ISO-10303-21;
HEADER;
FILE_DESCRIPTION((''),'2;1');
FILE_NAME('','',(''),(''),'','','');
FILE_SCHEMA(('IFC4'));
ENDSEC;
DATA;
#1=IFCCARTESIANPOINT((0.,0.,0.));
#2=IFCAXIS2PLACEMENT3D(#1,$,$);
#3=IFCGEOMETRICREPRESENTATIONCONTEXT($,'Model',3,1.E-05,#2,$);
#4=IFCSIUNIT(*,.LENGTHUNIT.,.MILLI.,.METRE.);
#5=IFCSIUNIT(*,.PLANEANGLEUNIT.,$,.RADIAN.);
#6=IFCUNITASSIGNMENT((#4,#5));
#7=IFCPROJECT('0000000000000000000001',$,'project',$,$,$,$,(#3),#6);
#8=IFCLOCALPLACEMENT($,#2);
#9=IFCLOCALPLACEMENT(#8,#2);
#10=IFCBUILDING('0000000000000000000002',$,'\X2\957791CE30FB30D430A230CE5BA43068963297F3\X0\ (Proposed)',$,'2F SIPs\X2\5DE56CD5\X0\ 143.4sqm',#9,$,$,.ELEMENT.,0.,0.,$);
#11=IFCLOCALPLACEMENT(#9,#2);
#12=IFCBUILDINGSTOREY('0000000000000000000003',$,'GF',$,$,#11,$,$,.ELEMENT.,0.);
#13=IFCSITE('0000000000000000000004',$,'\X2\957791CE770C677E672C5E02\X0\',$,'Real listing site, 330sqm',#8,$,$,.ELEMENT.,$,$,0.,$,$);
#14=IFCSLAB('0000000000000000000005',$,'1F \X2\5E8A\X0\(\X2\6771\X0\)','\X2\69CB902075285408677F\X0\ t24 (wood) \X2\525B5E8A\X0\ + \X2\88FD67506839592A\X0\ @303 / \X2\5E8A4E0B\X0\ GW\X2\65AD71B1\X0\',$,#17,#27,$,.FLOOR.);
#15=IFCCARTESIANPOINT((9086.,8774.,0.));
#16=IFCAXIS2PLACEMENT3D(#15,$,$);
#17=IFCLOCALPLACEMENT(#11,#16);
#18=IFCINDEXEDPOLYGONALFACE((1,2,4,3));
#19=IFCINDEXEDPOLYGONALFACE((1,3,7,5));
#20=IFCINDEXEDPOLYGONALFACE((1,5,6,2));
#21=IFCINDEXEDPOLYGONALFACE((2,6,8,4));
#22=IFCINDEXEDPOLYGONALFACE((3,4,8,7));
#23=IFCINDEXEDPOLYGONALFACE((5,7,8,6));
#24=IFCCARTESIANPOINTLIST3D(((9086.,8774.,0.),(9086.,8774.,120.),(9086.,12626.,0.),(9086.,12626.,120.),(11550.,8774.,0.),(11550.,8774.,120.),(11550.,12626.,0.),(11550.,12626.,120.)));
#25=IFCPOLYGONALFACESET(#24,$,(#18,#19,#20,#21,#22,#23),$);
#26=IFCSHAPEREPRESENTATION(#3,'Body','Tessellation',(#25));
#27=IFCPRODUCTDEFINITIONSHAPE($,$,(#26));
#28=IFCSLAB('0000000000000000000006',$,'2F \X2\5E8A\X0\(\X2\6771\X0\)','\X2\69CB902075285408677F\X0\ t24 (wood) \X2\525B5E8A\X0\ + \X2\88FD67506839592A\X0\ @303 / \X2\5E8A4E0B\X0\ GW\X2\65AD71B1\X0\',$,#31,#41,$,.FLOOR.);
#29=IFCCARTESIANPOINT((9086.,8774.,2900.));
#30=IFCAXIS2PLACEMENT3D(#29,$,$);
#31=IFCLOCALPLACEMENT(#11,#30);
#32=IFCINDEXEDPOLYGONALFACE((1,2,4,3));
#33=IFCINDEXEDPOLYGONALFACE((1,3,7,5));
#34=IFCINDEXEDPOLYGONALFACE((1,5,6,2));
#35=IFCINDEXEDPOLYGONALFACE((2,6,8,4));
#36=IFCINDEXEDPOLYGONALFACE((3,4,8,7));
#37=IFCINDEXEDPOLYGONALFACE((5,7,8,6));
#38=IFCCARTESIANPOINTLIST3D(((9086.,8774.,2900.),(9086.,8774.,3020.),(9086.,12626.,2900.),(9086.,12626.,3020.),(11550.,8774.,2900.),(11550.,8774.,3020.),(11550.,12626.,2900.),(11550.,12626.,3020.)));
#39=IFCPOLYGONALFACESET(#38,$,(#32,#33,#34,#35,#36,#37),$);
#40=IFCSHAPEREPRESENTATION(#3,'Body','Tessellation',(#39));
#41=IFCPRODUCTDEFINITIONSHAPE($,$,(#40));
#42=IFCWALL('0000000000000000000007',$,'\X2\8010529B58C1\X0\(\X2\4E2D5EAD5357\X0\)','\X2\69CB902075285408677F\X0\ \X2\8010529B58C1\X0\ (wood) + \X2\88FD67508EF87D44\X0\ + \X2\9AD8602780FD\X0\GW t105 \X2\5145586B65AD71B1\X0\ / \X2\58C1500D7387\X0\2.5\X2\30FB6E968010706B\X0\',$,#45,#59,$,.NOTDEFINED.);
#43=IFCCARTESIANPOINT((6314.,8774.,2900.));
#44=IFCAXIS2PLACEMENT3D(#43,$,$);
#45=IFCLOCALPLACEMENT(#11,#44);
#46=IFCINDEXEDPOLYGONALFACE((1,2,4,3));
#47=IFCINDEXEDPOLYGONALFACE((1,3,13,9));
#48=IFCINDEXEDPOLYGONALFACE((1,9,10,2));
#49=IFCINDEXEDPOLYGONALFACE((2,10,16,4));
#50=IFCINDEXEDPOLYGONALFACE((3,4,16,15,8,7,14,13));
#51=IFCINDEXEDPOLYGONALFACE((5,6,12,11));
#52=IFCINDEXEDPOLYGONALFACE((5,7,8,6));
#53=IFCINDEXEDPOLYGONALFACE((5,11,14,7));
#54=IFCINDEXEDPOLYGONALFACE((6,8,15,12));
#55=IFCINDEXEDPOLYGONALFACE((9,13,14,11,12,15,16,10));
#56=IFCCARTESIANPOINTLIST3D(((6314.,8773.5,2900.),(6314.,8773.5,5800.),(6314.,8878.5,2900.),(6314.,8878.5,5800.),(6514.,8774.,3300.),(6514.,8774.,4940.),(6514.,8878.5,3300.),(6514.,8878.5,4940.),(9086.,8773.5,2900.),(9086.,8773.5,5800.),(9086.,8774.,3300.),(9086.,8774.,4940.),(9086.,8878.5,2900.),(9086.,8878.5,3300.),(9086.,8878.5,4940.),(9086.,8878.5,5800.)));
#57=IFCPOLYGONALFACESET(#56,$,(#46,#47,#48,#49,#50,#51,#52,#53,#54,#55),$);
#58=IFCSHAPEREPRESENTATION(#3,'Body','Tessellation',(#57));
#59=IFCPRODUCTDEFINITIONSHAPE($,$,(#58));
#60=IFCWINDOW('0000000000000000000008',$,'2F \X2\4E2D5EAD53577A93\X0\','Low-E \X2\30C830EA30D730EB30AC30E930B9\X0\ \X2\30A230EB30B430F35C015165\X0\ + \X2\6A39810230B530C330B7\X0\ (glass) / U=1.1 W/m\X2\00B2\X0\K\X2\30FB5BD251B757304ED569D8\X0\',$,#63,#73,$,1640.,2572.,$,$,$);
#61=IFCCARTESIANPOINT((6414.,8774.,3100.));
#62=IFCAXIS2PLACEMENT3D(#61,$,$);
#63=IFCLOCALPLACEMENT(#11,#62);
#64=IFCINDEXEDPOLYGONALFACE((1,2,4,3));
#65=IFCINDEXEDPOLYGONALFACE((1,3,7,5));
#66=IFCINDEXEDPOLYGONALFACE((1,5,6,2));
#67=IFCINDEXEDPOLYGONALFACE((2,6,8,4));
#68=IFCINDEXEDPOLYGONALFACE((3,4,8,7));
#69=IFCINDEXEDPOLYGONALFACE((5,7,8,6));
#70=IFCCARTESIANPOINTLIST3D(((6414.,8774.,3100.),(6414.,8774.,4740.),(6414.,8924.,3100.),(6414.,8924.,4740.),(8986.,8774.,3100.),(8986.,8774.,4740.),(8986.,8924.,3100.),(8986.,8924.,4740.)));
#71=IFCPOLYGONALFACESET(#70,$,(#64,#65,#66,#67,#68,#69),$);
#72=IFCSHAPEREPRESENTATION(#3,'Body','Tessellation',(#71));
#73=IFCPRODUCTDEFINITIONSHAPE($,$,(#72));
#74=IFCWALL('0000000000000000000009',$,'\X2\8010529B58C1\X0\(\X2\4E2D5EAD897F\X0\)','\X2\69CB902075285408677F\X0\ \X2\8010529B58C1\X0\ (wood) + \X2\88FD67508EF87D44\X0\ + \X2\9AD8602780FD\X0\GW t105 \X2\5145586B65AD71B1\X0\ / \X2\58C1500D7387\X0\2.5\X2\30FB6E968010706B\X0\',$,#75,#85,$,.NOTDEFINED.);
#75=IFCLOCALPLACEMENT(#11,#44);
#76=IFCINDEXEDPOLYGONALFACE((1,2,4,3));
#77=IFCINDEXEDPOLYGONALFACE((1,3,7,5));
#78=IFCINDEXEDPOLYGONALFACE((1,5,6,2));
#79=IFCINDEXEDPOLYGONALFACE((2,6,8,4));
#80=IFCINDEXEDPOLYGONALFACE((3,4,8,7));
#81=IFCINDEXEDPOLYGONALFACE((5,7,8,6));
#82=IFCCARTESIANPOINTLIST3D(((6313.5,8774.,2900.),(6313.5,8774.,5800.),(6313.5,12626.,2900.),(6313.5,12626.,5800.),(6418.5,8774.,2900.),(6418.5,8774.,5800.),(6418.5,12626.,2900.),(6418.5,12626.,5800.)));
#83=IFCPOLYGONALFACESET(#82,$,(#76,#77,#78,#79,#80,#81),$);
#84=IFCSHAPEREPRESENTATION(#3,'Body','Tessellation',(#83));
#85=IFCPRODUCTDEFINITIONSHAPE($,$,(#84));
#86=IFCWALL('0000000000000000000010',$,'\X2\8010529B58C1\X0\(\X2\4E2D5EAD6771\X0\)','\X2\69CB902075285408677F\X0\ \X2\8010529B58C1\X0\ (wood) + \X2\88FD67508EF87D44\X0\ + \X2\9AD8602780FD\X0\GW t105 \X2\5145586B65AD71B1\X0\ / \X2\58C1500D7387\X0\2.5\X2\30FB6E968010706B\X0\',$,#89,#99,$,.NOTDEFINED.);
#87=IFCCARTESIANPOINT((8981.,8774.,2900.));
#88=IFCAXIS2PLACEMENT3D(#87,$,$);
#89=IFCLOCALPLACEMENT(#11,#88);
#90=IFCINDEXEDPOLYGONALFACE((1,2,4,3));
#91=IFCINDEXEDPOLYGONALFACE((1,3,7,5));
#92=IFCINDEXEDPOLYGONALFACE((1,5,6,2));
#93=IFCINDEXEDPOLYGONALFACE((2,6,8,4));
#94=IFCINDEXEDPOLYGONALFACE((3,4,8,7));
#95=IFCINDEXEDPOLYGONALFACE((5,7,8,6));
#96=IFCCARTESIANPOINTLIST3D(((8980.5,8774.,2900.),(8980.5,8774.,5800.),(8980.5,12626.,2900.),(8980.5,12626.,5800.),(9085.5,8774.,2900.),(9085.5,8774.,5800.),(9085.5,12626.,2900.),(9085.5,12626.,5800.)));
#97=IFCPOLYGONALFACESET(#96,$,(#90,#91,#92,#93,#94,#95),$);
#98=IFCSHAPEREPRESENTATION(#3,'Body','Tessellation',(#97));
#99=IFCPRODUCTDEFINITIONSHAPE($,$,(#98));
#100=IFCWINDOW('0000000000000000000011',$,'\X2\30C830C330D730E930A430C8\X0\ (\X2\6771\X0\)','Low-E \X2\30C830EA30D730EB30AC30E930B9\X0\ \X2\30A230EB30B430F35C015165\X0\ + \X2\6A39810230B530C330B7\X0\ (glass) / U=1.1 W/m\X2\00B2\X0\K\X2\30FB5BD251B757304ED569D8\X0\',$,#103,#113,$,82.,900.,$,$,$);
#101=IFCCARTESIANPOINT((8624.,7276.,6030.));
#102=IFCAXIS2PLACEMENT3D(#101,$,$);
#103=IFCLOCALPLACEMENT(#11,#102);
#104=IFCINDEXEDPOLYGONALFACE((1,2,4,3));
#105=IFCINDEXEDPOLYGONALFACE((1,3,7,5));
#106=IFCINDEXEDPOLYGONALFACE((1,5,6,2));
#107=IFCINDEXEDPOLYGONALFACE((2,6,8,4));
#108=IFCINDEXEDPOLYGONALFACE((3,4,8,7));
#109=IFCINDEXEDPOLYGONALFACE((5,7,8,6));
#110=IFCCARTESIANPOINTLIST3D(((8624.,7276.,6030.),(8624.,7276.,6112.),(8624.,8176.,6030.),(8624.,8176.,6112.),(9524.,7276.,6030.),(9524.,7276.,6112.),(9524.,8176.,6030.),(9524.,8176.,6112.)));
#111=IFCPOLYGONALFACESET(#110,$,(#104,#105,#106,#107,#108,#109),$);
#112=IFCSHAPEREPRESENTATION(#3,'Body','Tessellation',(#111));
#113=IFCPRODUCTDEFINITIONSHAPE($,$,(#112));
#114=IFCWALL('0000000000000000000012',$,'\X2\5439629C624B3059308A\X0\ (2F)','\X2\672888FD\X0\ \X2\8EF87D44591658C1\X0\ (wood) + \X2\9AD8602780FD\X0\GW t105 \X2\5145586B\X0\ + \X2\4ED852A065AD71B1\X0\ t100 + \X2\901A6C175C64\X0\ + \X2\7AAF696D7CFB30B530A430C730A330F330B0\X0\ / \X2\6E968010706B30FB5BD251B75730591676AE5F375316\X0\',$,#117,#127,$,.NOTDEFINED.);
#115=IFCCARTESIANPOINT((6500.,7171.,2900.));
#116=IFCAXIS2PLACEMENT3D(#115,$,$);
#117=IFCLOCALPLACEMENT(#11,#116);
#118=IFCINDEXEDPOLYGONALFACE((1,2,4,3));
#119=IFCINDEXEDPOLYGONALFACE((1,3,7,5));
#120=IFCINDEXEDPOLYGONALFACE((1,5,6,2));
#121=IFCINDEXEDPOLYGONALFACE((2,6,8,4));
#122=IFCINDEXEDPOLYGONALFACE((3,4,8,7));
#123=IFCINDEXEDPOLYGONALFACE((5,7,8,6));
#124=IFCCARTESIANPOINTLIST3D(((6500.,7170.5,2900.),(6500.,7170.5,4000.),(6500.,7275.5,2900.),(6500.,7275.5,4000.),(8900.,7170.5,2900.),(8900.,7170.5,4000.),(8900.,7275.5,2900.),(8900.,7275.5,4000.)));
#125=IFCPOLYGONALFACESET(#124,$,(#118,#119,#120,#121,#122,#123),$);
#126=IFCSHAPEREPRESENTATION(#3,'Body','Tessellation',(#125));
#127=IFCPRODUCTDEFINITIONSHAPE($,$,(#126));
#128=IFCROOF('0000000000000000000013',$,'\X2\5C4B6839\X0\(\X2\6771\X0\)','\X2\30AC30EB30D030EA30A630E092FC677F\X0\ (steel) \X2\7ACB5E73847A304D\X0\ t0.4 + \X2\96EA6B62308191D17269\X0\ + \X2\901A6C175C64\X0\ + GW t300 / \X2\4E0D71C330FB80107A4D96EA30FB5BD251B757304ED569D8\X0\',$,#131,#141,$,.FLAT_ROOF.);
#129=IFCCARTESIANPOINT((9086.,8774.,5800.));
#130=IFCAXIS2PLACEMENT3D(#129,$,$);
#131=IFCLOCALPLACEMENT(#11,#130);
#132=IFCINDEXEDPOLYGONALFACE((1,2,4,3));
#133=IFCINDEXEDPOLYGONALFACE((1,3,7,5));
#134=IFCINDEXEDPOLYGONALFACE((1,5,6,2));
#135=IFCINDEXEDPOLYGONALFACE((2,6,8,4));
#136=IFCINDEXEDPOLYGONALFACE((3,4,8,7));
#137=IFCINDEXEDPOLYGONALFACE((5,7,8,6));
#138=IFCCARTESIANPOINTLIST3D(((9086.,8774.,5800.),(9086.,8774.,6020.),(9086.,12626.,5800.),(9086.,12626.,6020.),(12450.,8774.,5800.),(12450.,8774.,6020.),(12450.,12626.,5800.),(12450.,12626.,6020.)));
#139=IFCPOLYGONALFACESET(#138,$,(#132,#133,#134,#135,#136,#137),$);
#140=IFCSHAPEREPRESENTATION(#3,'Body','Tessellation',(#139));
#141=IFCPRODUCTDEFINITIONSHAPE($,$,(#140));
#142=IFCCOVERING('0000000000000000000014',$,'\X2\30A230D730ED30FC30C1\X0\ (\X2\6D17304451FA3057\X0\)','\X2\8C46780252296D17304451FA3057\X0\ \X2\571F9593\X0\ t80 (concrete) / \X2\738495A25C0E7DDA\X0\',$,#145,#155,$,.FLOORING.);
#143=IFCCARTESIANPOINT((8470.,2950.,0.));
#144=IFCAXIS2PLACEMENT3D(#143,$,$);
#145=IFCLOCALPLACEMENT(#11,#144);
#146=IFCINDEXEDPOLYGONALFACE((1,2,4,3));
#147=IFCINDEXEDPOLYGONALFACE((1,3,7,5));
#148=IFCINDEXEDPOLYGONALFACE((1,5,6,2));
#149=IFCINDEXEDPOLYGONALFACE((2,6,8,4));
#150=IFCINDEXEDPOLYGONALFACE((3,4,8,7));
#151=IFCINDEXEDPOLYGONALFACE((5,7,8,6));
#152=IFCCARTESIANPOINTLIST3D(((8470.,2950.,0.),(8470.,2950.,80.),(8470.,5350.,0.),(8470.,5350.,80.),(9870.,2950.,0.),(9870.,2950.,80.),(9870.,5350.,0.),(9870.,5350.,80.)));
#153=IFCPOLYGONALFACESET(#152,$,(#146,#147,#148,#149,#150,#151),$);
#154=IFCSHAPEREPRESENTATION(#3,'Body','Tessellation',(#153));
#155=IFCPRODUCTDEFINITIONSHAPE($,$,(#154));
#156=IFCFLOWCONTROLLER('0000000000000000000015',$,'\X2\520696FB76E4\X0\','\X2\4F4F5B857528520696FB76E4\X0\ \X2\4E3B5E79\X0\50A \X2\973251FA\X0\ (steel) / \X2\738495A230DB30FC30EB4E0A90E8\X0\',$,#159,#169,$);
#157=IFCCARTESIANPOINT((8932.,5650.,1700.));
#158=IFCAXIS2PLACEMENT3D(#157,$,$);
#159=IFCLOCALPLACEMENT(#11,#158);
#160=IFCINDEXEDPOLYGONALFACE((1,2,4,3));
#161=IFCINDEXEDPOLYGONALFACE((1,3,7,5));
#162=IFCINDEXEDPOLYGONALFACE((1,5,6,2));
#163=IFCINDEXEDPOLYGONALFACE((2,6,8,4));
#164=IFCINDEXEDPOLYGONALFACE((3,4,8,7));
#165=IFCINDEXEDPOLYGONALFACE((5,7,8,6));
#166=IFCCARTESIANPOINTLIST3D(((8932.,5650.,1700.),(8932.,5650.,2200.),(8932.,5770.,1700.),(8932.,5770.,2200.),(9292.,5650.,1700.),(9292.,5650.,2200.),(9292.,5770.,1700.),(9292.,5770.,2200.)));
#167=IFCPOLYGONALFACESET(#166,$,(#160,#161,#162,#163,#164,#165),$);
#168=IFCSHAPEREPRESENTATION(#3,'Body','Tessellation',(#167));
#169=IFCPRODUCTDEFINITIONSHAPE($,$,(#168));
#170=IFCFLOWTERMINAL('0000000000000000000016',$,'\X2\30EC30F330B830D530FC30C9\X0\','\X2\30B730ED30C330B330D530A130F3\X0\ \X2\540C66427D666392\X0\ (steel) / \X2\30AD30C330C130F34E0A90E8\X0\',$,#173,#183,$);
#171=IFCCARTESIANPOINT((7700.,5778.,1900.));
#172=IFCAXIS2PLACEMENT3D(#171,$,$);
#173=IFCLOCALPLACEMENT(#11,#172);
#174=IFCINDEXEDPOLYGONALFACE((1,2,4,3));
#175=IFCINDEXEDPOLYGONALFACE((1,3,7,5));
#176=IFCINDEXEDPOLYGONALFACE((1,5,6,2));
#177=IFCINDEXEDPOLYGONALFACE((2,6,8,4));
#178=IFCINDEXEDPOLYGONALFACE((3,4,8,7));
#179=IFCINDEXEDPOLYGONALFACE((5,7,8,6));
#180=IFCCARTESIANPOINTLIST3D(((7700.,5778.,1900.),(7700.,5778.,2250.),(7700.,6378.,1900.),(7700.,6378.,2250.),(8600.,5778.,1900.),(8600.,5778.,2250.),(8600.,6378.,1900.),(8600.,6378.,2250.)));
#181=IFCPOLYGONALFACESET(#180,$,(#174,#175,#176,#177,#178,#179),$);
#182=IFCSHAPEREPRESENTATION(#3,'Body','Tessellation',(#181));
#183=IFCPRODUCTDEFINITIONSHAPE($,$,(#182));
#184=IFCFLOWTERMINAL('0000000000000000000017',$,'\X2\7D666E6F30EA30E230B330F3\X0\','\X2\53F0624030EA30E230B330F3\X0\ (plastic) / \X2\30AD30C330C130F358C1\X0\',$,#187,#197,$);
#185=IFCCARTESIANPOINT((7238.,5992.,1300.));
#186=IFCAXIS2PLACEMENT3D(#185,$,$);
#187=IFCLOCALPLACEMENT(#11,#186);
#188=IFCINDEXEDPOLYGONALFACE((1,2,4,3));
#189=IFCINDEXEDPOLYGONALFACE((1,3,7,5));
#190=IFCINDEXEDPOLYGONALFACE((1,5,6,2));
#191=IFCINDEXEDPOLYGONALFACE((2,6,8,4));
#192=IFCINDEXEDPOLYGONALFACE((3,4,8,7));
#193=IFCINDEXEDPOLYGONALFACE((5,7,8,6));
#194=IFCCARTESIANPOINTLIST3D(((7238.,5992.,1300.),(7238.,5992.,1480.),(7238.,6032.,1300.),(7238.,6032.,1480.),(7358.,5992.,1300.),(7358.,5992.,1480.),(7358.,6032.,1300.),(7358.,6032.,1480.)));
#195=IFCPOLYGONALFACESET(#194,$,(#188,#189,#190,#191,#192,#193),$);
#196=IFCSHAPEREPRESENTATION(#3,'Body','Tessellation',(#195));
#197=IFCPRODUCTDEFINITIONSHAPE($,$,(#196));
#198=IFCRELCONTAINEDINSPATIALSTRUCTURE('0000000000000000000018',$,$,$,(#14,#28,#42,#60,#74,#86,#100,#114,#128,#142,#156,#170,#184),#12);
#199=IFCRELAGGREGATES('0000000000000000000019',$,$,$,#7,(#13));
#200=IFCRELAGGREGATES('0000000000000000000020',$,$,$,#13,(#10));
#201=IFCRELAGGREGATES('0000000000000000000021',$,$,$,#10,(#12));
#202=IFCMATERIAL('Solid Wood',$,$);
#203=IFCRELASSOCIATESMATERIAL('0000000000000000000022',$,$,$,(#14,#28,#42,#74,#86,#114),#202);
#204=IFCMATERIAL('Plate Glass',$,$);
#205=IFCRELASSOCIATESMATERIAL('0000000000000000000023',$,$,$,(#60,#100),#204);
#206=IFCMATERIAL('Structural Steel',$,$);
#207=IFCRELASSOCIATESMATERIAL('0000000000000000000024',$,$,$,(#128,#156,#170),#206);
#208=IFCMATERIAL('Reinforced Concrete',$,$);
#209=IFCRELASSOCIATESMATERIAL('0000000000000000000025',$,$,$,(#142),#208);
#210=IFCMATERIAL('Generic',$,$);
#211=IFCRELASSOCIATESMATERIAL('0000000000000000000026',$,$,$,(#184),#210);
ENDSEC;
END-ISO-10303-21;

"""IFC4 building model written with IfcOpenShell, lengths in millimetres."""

from ifc_helpers import new_model, si_unit, frame, frame_2d, origin, place, context, project, spatial, rectangle, extrude, material, element, fill, save


model = new_model("IFC4")

# Units and contexts
model_context = context("Model", 3, precision=1e-05, world=origin())
ifc_project = project(units=[si_unit("LENGTHUNIT", "METRE", prefix="MILLI"), si_unit("PLANEANGLEUNIT", "RADIAN")], contexts=[model_context])

# Site, building, storey
site_placement = place(None, origin())
site = spatial("IfcSite", under=ifc_project, at=site_placement, Name="長野県松本市", ObjectType="Real listing site, 330sqm", CompositionType="ELEMENT", RefElevation=0.0)
building_placement = place(site_placement, origin())
building = spatial("IfcBuilding", under=site, at=building_placement, Name="長野・ピアノ室と防音 (Proposed)", ObjectType="2F SIPs工法 143.4sqm", CompositionType="ELEMENT", ElevationOfRefHeight=0.0, ElevationOfTerrain=0.0)
storey_placement = place(building_placement, origin())
storey = spatial("IfcBuildingStorey", under=building, at=storey_placement, Name="GF", CompositionType="ELEMENT", Elevation=0.0)

# Shared definitions
ifc_material_1 = material(Name="Solid Wood")

# Slabs
slab_1_placement = place(storey_placement, frame((9086.0, 8774.0, 0.0)))
element("IfcSlab", 1, at=slab_1_placement, inside=storey, material=ifc_material_1, Name="1F 床(東)", Description="構造用合板 t24 (wood) 剛床 + 製材根太 @303 / 床下 GW断熱", PredefinedType="FLOOR", context=model_context, shape_type="SweptSolid", body=[
    extrude(rectangle(XDim=2464.0, YDim=3852.0, at=frame_2d((1232.0, 1926.0))), frame((9086.0, 8774.0, 0.0)), (0.0, 0.0, 1.0), 120.0),
])
slab_2_placement = place(storey_placement, frame((9086.0, 8774.0, 2900.0)))
element("IfcSlab", 2, at=slab_2_placement, inside=storey, material=ifc_material_1, Name="2F 床(東)", Description="構造用合板 t24 (wood) 剛床 + 製材根太 @303 / 床下 GW断熱", PredefinedType="FLOOR", context=model_context, shape_type="SweptSolid", body=[
    extrude(rectangle(XDim=2464.0, YDim=3852.0, at=frame_2d((1232.0, 1926.0))), frame((9086.0, 8774.0, 2900.0)), (0.0, 0.0, 1.0), 120.0),
])

# Wall, opening, window
wall_1_placement = place(storey_placement, frame((6314.0, 8774.0, 2900.0)))
wall_1 = element("IfcWall", 3, at=wall_1_placement, inside=storey, material=ifc_material_1, Name="耐力壁(中庭南)", Description="構造用合板 耐力壁 (wood) + 製材軸組 + 高性能GW t105 充填断熱 / 壁倍率2.5・準耐火", PredefinedType="NOTDEFINED", context=model_context, shape_type="SweptSolid", body=[
    extrude(rectangle(XDim=2772.0, YDim=105.0, at=frame_2d((1386.0, 52.0))), frame((6314.0, 8774.0, 2900.0)), (0.0, 0.0, 1.0), 2900.0),
])
opening_placement = place(storey_placement, frame((6414.0, 8774.0, 3100.0)))
opening = element("IfcOpeningElement", 4, at=opening_placement, cuts=wall_1, PredefinedType="NOTDEFINED", context=model_context, shape_type="SweptSolid", body=[
    extrude(rectangle(XDim=2572.0, YDim=150.0, at=frame_2d((1286.0, 75.0))), frame((6414.0, 8774.0, 3100.0)), (0.0, 0.0, 1.0), 1640.0),
])
ifc_material_2 = material(Name="Plate Glass")
window_1_placement = place(storey_placement, frame((6414.0, 8774.0, 3100.0)))
window_1 = element("IfcWindow", 5, at=window_1_placement, inside=storey, material=ifc_material_2, Name="2F 中庭南窓", Description="Low-E トリプルガラス アルゴン封入 + 樹脂サッシ (glass) / U=1.1 W/m²K・寒冷地仕様", OverallHeight=1640.0, OverallWidth=2572.0, context=model_context, shape_type="SweptSolid", body=[
    extrude(rectangle(XDim=2572.0, YDim=150.0, at=frame_2d((1286.0, 75.0))), frame((6414.0, 8774.0, 3100.0)), (0.0, 0.0, 1.0), 1640.0),
])
fill(opening, window_1)

# Walls
wall_2_placement = place(storey_placement, frame((6314.0, 8774.0, 2900.0)))
element("IfcWall", 6, at=wall_2_placement, inside=storey, material=ifc_material_1, Name="耐力壁(中庭西)", Description="構造用合板 耐力壁 (wood) + 製材軸組 + 高性能GW t105 充填断熱 / 壁倍率2.5・準耐火", PredefinedType="NOTDEFINED", context=model_context, shape_type="SweptSolid", body=[
    extrude(rectangle(XDim=105.0, YDim=3852.0, at=frame_2d((52.0, 1926.0))), frame((6314.0, 8774.0, 2900.0)), (0.0, 0.0, 1.0), 2900.0),
])
wall_3_placement = place(storey_placement, frame((8981.0, 8774.0, 2900.0)))
element("IfcWall", 7, at=wall_3_placement, inside=storey, material=ifc_material_1, Name="耐力壁(中庭東)", Description="構造用合板 耐力壁 (wood) + 製材軸組 + 高性能GW t105 充填断熱 / 壁倍率2.5・準耐火", PredefinedType="NOTDEFINED", context=model_context, shape_type="SweptSolid", body=[
    extrude(rectangle(XDim=105.0, YDim=3852.0, at=frame_2d((52.0, 1926.0))), frame((8981.0, 8774.0, 2900.0)), (0.0, 0.0, 1.0), 2900.0),
])

# Window
window_2_placement = place(storey_placement, frame((8624.0, 7276.0, 6030.0)))
element("IfcWindow", 8, at=window_2_placement, inside=storey, material=ifc_material_2, Name="トップライト (東)", Description="Low-E トリプルガラス アルゴン封入 + 樹脂サッシ (glass) / U=1.1 W/m²K・寒冷地仕様", OverallHeight=82.0, OverallWidth=900.0, context=model_context, shape_type="SweptSolid", body=[
    extrude(rectangle(XDim=900.0, YDim=900.0, at=frame_2d((450.0, 450.0))), frame((8624.0, 7276.0, 6030.0)), (0.0, 0.0, 1.0), 82.0),
])

# Wall
wall_4_placement = place(storey_placement, frame((6500.0, 7171.0, 2900.0)))
element("IfcWall", 9, at=wall_4_placement, inside=storey, material=ifc_material_1, Name="吹抜手すり (2F)", Description="木製 軸組外壁 (wood) + 高性能GW t105 充填 + 付加断熱 t100 + 通気層 + 窯業系サイディング / 準耐火・寒冷地外皮強化", PredefinedType="NOTDEFINED", context=model_context, shape_type="SweptSolid", body=[
    extrude(rectangle(XDim=2400.0, YDim=105.0, at=frame_2d((1200.0, 52.0))), frame((6500.0, 7171.0, 2900.0)), (0.0, 0.0, 1.0), 1100.0),
])

# Roof
ifc_material_3 = material(Name="Structural Steel")
for number, where, name in (
    (10, (9086.0, 8774.0, 5800.0), "屋根(東)"),
):
    element("IfcRoof", number, at=place(storey_placement, frame(where)), inside=storey, material=ifc_material_3, Name=name, Description="ガルバリウム鋼板 (steel) 立平葺き t0.4 + 雪止め金物 + 通気層 + GW t300 / 不燃・耐積雪・寒冷地仕様", PredefinedType="FLAT_ROOF", context=model_context, shape_type="SweptSolid", body=[
        extrude(rectangle(XDim=3364.0, YDim=3852.0, at=frame_2d((1682.0, 1926.0))), frame((9086.0, 8774.0, 5800.0)), (0.0, 0.0, 1.0), 220.0),
    ])

# Covering
ifc_material_4 = material(Name="Reinforced Concrete")
covering_placement = place(storey_placement, frame((8470.0, 2950.0, 0.0)))
element("IfcCovering", 11, at=covering_placement, inside=storey, material=ifc_material_4, Name="アプローチ (洗い出し)", Description="豆砂利洗い出し 土間 t80 (concrete) / 玄関導線", PredefinedType="FLOORING", context=model_context, shape_type="SweptSolid", body=[
    extrude(rectangle(XDim=1400.0, YDim=2400.0, at=frame_2d((700.0, 1200.0))), frame((8470.0, 2950.0, 0.0)), (0.0, 0.0, 1.0), 80.0),
])

# Flow controller
flow_controller_placement = place(storey_placement, frame((8932.0, 5650.0, 1700.0)))
element("IfcFlowController", 12, at=flow_controller_placement, inside=storey, material=ifc_material_3, Name="分電盤", Description="住宅用分電盤 主幹50A 露出 (steel) / 玄関ホール上部", context=model_context, shape_type="SweptSolid", body=[
    extrude(rectangle(XDim=360.0, YDim=120.0, at=frame_2d((180.0, 60.0))), frame((8932.0, 5650.0, 1700.0)), (0.0, 0.0, 1.0), 500.0),
])

# Flow terminals
flow_terminal_1_placement = place(storey_placement, frame((7700.0, 5778.0, 1900.0)))
element("IfcFlowTerminal", 13, at=flow_terminal_1_placement, inside=storey, material=ifc_material_3, Name="レンジフード", Description="シロッコファン 同時給排 (steel) / キッチン上部", context=model_context, shape_type="SweptSolid", body=[
    extrude(rectangle(XDim=900.0, YDim=600.0, at=frame_2d((450.0, 300.0))), frame((7700.0, 5778.0, 1900.0)), (0.0, 0.0, 1.0), 350.0),
])
ifc_material_5 = material(Name="Generic")
flow_terminal_2_placement = place(storey_placement, frame((7238.0, 5992.0, 1300.0)))
element("IfcFlowTerminal", 14, at=flow_terminal_2_placement, inside=storey, material=ifc_material_5, Name="給湯リモコン", Description="台所リモコン (plastic) / キッチン壁", context=model_context, shape_type="SweptSolid", body=[
    extrude(rectangle(XDim=120.0, YDim=40.0, at=frame_2d((60.0, 20.0))), frame((7238.0, 5992.0, 1300.0)), (0.0, 0.0, 1.0), 180.0),
])

save(model, "model.ifc")
